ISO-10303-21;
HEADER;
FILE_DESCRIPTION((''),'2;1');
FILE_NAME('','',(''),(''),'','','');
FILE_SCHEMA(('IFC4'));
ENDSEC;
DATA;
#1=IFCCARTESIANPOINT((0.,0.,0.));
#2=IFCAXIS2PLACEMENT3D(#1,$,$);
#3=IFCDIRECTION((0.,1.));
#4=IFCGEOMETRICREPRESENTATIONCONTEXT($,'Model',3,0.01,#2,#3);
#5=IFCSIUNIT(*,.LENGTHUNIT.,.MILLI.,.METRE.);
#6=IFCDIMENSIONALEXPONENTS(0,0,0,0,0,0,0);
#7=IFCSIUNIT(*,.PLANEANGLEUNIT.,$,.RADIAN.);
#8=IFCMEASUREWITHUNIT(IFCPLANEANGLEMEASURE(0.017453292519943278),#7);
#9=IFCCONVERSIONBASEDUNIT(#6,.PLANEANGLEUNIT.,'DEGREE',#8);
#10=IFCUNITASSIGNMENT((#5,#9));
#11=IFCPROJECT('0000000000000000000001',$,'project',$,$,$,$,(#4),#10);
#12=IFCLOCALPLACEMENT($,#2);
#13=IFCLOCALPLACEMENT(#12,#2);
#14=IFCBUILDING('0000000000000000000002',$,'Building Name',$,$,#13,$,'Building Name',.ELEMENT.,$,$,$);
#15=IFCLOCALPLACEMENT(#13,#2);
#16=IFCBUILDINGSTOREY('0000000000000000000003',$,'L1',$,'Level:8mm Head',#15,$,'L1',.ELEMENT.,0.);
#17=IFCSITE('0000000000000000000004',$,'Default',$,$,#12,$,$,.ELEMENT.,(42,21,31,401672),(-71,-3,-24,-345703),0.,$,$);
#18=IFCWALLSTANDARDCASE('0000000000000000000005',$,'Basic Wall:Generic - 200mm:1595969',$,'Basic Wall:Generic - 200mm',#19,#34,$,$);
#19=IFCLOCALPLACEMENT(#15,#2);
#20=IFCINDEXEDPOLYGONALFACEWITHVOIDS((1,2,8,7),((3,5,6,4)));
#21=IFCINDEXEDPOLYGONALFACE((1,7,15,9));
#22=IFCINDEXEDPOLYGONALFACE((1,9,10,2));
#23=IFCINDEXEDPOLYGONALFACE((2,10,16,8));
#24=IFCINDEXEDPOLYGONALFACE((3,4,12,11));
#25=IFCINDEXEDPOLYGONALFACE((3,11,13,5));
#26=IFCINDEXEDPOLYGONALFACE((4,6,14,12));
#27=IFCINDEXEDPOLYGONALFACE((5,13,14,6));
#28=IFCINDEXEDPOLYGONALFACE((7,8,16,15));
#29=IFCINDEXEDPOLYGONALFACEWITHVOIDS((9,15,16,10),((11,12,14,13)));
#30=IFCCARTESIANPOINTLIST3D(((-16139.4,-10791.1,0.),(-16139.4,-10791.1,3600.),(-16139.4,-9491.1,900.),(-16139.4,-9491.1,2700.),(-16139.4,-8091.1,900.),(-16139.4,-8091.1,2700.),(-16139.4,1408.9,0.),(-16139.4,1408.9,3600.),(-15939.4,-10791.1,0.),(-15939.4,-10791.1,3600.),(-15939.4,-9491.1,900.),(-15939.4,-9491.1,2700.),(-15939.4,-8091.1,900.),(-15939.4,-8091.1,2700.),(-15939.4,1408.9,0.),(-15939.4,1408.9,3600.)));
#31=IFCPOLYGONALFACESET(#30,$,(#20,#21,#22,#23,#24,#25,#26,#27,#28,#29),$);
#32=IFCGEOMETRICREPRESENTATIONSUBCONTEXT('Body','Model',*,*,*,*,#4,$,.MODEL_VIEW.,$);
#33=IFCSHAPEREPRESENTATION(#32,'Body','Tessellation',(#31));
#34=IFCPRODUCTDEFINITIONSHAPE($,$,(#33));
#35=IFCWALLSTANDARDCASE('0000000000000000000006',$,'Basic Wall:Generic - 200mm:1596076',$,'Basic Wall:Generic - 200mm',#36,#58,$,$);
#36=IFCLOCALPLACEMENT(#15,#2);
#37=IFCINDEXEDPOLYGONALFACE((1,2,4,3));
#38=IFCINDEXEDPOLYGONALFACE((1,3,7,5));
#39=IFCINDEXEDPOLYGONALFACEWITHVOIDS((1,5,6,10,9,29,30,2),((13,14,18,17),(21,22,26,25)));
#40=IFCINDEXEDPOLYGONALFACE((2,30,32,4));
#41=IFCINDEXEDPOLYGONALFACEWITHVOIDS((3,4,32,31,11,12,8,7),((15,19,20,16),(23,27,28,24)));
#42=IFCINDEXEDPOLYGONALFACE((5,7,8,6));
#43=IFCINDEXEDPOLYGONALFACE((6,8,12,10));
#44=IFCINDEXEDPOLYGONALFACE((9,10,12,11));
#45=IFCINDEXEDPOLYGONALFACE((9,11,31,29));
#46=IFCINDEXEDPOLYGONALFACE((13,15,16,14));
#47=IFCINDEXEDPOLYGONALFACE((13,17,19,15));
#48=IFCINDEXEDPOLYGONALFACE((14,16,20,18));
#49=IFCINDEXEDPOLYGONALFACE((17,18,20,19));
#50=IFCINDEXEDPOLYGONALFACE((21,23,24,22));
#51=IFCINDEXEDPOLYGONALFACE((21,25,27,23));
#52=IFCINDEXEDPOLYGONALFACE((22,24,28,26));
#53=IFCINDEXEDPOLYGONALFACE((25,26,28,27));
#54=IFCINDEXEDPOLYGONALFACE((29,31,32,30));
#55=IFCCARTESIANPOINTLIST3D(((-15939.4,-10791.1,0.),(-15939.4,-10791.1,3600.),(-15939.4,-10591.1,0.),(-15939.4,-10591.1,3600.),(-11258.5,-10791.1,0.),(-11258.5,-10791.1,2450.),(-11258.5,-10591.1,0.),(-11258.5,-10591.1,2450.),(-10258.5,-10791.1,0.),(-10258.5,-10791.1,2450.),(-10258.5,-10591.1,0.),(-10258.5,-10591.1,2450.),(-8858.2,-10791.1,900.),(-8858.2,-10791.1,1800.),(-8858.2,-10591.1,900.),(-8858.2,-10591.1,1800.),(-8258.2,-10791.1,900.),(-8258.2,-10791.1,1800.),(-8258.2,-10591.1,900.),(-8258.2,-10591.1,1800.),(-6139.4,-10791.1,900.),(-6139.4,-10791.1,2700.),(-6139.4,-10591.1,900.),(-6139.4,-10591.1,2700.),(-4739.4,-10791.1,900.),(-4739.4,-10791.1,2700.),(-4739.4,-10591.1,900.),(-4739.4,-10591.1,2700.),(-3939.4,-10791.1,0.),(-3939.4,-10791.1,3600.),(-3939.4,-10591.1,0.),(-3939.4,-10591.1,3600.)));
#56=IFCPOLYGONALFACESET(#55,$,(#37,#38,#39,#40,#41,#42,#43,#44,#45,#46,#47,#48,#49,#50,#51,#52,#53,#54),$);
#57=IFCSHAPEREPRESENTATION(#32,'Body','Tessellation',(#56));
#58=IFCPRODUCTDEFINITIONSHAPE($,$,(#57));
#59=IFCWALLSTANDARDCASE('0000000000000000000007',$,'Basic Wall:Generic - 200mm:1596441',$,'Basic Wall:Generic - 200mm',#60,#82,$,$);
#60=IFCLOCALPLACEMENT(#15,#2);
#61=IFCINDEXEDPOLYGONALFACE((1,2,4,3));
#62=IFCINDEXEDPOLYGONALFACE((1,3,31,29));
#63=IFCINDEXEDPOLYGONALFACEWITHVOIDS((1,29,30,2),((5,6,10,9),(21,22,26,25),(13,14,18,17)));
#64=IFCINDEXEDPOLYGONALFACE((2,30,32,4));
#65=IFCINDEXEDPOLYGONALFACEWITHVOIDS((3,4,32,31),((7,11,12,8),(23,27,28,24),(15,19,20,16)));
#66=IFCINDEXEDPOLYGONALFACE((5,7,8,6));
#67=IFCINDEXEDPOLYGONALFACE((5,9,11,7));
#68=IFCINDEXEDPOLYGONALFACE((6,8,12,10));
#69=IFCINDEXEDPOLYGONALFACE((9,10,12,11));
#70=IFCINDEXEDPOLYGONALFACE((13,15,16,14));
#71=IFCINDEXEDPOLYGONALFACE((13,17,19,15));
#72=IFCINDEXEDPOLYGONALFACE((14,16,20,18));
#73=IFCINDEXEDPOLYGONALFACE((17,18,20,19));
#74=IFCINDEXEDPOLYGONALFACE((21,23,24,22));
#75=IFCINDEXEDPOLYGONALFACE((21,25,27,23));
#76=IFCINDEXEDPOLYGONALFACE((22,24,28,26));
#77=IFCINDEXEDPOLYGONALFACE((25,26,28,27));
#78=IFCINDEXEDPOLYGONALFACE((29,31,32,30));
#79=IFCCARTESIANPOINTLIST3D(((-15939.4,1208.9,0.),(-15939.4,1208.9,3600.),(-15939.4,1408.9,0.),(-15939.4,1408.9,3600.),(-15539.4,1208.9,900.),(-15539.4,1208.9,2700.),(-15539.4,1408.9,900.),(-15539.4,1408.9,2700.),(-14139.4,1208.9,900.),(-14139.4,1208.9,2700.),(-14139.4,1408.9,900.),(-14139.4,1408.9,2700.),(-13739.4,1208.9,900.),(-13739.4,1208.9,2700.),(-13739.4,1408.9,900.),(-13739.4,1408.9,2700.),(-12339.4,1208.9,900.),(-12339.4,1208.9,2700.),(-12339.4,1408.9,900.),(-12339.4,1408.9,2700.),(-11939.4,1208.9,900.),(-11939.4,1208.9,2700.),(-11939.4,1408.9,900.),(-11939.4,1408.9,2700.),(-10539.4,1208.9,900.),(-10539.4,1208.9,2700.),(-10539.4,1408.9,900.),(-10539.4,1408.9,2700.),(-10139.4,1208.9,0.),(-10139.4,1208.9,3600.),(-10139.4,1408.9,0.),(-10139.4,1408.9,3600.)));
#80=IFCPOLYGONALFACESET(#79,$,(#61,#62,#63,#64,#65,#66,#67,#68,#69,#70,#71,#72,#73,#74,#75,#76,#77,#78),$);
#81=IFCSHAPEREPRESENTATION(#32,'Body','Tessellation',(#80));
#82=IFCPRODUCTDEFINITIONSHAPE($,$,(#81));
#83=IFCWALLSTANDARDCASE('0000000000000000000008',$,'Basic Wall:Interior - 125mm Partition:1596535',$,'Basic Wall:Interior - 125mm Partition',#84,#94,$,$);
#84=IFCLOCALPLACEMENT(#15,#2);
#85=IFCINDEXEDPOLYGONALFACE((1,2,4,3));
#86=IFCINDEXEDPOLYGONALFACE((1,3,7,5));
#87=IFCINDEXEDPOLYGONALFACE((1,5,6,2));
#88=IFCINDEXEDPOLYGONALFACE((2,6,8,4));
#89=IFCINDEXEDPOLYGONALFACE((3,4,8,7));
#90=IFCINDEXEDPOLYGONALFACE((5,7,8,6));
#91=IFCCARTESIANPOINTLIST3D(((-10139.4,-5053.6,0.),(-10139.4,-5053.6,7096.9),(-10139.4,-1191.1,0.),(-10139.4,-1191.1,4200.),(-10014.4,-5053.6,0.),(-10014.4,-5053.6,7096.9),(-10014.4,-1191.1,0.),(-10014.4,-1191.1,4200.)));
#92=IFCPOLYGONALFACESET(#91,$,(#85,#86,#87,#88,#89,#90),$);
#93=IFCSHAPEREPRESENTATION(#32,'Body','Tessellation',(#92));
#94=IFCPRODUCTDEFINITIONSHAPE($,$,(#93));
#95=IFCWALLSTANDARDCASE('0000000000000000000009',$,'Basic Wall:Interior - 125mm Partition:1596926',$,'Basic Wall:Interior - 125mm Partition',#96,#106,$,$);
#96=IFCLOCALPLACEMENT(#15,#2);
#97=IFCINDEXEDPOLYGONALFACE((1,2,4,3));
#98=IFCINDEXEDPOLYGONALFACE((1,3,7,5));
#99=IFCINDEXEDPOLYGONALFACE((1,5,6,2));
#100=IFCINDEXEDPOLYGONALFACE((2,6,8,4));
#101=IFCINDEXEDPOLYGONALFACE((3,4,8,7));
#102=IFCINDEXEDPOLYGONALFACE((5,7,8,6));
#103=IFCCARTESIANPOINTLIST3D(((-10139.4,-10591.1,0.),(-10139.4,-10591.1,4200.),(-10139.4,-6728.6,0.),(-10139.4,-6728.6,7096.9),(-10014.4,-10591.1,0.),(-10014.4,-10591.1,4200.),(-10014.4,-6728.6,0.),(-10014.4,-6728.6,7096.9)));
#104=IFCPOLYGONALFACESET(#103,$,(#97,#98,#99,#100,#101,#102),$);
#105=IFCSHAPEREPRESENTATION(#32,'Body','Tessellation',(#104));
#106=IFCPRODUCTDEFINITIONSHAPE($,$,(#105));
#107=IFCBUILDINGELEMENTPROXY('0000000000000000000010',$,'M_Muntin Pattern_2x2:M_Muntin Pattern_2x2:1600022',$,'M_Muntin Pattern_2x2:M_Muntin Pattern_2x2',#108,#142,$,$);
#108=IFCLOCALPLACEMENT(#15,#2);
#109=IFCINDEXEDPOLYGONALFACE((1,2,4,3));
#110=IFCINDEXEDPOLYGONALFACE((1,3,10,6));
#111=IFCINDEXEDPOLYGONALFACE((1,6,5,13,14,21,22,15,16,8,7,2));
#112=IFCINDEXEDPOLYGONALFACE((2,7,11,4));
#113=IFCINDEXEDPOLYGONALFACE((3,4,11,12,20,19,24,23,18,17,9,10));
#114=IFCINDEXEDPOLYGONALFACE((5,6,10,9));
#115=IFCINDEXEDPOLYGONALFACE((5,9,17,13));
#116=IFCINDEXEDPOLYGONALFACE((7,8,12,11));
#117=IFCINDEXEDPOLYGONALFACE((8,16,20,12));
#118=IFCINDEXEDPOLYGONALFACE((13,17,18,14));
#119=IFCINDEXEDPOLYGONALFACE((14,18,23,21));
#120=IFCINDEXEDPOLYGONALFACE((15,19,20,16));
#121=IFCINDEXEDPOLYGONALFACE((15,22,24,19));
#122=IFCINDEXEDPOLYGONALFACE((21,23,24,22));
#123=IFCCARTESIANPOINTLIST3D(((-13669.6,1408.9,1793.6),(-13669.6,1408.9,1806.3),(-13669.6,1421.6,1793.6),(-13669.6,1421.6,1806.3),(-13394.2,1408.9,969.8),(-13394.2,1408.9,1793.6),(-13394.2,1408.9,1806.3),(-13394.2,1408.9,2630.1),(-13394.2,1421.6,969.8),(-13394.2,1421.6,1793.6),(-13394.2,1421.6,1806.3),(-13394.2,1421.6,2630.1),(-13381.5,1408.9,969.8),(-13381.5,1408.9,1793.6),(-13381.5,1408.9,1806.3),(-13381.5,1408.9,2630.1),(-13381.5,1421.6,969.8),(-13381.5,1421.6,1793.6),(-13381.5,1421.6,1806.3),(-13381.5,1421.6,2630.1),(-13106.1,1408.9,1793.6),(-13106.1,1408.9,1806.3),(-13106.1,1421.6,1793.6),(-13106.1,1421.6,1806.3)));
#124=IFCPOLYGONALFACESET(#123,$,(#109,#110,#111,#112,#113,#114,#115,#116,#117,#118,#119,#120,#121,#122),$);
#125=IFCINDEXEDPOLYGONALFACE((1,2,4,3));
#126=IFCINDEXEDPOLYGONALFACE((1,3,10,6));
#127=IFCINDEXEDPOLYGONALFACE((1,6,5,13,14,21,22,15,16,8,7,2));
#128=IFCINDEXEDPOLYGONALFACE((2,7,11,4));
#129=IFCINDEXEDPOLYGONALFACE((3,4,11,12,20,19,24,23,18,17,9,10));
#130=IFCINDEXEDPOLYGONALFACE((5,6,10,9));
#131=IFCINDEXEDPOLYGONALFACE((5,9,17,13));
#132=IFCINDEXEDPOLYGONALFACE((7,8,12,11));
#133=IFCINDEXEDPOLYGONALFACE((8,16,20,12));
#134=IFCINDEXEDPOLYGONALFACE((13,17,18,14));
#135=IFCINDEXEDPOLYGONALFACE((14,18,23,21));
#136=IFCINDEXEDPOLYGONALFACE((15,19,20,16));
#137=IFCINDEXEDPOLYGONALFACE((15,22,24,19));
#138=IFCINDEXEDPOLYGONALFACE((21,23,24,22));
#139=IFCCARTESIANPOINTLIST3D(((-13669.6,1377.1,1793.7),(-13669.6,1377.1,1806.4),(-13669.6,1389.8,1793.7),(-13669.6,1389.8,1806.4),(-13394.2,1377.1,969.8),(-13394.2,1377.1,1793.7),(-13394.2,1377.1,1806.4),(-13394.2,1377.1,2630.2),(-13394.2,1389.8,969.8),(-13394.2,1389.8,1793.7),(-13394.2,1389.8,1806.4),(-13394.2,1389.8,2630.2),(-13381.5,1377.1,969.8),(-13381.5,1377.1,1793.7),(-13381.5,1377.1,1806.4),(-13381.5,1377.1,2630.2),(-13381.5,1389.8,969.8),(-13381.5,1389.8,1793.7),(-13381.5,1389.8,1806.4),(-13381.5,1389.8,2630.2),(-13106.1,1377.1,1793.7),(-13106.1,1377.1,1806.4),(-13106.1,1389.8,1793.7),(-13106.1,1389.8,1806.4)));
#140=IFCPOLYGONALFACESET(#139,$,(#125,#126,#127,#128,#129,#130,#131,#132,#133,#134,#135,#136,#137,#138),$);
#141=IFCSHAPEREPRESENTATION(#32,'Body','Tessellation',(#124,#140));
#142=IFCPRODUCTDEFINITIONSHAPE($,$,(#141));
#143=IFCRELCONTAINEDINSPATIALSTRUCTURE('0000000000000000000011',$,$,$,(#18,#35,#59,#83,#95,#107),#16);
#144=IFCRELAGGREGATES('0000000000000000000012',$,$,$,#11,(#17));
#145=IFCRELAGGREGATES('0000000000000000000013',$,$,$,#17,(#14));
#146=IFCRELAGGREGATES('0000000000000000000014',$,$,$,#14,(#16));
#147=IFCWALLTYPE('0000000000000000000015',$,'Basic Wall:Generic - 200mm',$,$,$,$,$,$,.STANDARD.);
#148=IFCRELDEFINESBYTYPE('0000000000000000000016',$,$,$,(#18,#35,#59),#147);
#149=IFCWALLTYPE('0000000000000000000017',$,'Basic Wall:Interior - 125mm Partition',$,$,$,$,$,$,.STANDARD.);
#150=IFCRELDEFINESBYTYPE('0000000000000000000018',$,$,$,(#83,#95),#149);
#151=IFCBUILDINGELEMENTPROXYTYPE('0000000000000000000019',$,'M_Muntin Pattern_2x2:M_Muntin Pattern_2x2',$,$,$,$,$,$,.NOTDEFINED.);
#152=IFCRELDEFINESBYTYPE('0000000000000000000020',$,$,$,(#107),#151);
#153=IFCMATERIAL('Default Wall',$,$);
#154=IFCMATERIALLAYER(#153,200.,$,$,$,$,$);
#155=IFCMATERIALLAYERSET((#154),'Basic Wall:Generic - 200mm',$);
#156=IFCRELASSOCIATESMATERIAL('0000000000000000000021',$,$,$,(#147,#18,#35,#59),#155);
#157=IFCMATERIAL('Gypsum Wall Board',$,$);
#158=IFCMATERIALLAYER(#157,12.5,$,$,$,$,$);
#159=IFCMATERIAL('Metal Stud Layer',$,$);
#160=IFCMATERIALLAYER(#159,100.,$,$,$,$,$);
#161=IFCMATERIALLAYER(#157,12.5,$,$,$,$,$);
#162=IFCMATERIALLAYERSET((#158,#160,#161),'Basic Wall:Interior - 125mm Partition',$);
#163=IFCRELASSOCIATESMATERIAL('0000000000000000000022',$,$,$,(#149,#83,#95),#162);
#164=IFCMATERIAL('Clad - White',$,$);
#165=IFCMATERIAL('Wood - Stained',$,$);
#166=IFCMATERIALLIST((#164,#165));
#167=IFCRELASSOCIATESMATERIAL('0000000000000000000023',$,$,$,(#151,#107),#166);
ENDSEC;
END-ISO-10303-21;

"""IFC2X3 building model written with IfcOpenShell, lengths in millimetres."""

from ifc_helpers import new_model, entity, si_unit, converted_unit, direction, frame, frame_2d, origin, place, context, subcontext, project, spatial, polyline, rectangle, outline, extrude, clip, bounded_halfspace, source, transform, mapped, material, material_list, layer, layer_set, layer_usage, type_object, type_shapes, element, save


model = new_model("IFC2X3")

# Units and contexts
model_context = context("Model", 3, precision=0.01, world=origin(), true_north=direction((0.0, 1.0)))
body_context = subcontext(model_context, "Body", "Model", "MODEL_VIEW")
ifc_project = project(units=[si_unit("LENGTHUNIT", "METRE", prefix="MILLI"), converted_unit("PLANEANGLEUNIT", "DEGREE", entity("IfcPlaneAngleMeasure", 0.017453292519943278), si_unit("PLANEANGLEUNIT", "RADIAN"), dimensions=[0, 0, 0, 0, 0, 0, 0])], contexts=[model_context])

# Site, building, storey
site_placement = place(None, origin())
site = spatial("IfcSite", under=ifc_project, at=site_placement, Name="Default", CompositionType="ELEMENT", RefLatitude=(42, 21, 31, 401672), RefLongitude=(-71, -3, -24, -345703), RefElevation=0.0)
building_placement = place(site_placement, origin())
building = spatial("IfcBuilding", under=site, at=building_placement, Name="Building Name", LongName="Building Name", CompositionType="ELEMENT")
storey_placement = place(building_placement, origin())
storey = spatial("IfcBuildingStorey", under=building, at=storey_placement, Name="L1", ObjectType="Level:8mm Head", LongName="L1", CompositionType="ELEMENT", Elevation=0.0)

# Wall, opening
ifc_material_1 = material(Name="Default Wall")
ifc_layer_1 = layer(ifc_material_1, 200.0)
ifc_layer_set_1 = layer_set([ifc_layer_1], Name="Basic Wall:Generic - 200mm")
ifc_layer_usage_1 = layer_usage(ifc_layer_set_1, "AXIS2", "NEGATIVE", 100.0)
wall_type_1 = type_object("IfcWallType", Name="Basic Wall:Generic - 200mm", PredefinedType="STANDARD", material=ifc_layer_set_1)
wall_1_placement = place(storey_placement, frame((-16039.4, 1408.9, 0.0), z_axis=(0.0, 0.0, 1.0), x_axis=(0.0, -1.0, 0.0)))
wall_1 = element("IfcWallStandardCase", 1, at=wall_1_placement, inside=storey, type_object=wall_type_1, material=ifc_layer_usage_1, Name="Basic Wall:Generic - 200mm:1595969", ObjectType="Basic Wall:Generic - 200mm", context=body_context, shape_type="SweptSolid", body=[
    extrude(rectangle(XDim=12200.0, YDim=200.0, at=frame_2d((6100.0, 0.0), x_axis=(-1.0, 0.0))), origin(), (0.0, 0.0, 1.0), 3600.0),
])
opening_1_placement = place(wall_1_placement, frame((10900.0, 100.0, 900.0)))
element("IfcOpeningElement", 2, at=opening_1_placement, cuts=wall_1, ObjectType="Opening", context=body_context, shape_type="SweptSolid", body=[
    extrude(rectangle(XDim=1800.0, YDim=1400.0, at=frame_2d((900.0, 700.0), x_axis=(-1.0, 0.0))), frame((0.0, 0.0, 0.0), z_axis=(0.0, -1.0, 0.0), x_axis=(0.0, 0.0, 1.0)), (0.0, 0.0, 1.0), 200.0),
])

# Walls, openings
wall_2_placement = place(storey_placement, frame((-15939.4, -10691.1, 0.0)))
wall_2 = element("IfcWallStandardCase", 3, at=wall_2_placement, inside=storey, type_object=wall_type_1, material=ifc_layer_usage_1, Name="Basic Wall:Generic - 200mm:1596076", ObjectType="Basic Wall:Generic - 200mm", context=body_context, shape_type="SweptSolid", body=[
    extrude(rectangle(XDim=12000.0, YDim=200.0, at=frame_2d((6000.0, 0.0), x_axis=(1.0, 0.0))), origin(), (0.0, 0.0, 1.0), 3600.0),
])
opening_2_placement = place(wall_2_placement, frame((4680.9, -100.0, 0.0)))
element("IfcOpeningElement", 4, at=opening_2_placement, cuts=wall_2, ObjectType="Opening", context=body_context, shape_type="SweptSolid", body=[
    extrude(rectangle(XDim=2450.0, YDim=1000.0, at=frame_2d((1225.0, 500.0), x_axis=(1.0, 0.0))), frame((0.0, 0.0, 0.0), z_axis=(0.0, 1.0, 0.0), x_axis=(0.0, 0.0, 1.0)), (0.0, 0.0, 1.0), 200.0),
])
opening_3_placement = place(wall_2_placement, frame((11200.0, 100.0, 900.0)))
element("IfcOpeningElement", 5, at=opening_3_placement, cuts=wall_2, ObjectType="Opening", context=body_context, shape_type="SweptSolid", body=[
    extrude(rectangle(XDim=1800.0, YDim=1400.0, at=frame_2d((900.0, 700.0), x_axis=(-1.0, 0.0))), frame((0.0, 0.0, 0.0), z_axis=(0.0, -1.0, 0.0), x_axis=(0.0, 0.0, 1.0)), (0.0, 0.0, 1.0), 200.0),
])
opening_4_placement = place(wall_2_placement, frame((7081.2, -100.0, 900.0)))
element("IfcOpeningElement", 6, at=opening_4_placement, cuts=wall_2, ObjectType="Opening", context=body_context, shape_type="SweptSolid", body=[
    extrude(rectangle(XDim=900.0, YDim=600.0, at=frame_2d((450.0, 300.0), x_axis=(-1.0, 0.0))), frame((0.0, 0.0, 0.0), z_axis=(0.0, 1.0, 0.0), x_axis=(0.0, 0.0, 1.0)), (0.0, 0.0, 1.0), 200.0),
])
wall_3_placement = place(storey_placement, frame((-10139.4, 1308.9, 0.0), z_axis=(0.0, 0.0, 1.0), x_axis=(-1.0, 0.0, 0.0)))
wall_3 = element("IfcWallStandardCase", 7, at=wall_3_placement, inside=storey, type_object=wall_type_1, material=ifc_layer_usage_1, Name="Basic Wall:Generic - 200mm:1596441", ObjectType="Basic Wall:Generic - 200mm", context=body_context, shape_type="SweptSolid", body=[
    extrude(rectangle(XDim=5800.0, YDim=200.0, at=frame_2d((2900.0, 0.0), x_axis=(-1.0, 0.0))), origin(), (0.0, 0.0, 1.0), 3600.0),
])
opening_5_placement = place(wall_3_placement, frame((3600.0, 100.0, 900.0)))
element("IfcOpeningElement", 8, at=opening_5_placement, cuts=wall_3, ObjectType="Opening", context=body_context, shape_type="SweptSolid", body=[
    extrude(rectangle(XDim=1800.0, YDim=1400.0, at=frame_2d((900.0, 700.0), x_axis=(-1.0, 0.0))), frame((0.0, 0.0, 0.0), z_axis=(0.0, -1.0, 0.0), x_axis=(0.0, 0.0, 1.0)), (0.0, 0.0, 1.0), 200.0),
])
opening_6_placement = place(wall_3_placement, frame((1800.0, 100.0, 900.0)))
element("IfcOpeningElement", 9, at=opening_6_placement, cuts=wall_3, ObjectType="Opening", context=body_context, shape_type="SweptSolid", body=[
    extrude(rectangle(XDim=1800.0, YDim=1400.0, at=frame_2d((900.0, 700.0), x_axis=(-1.0, 0.0))), frame((0.0, 0.0, 0.0), z_axis=(0.0, -1.0, 0.0), x_axis=(0.0, 0.0, 1.0)), (0.0, 0.0, 1.0), 200.0),
])
opening_7_placement = place(wall_3_placement, frame((5400.0, 100.0, 900.0)))
element("IfcOpeningElement", 10, at=opening_7_placement, cuts=wall_3, ObjectType="Opening", context=body_context, shape_type="SweptSolid", body=[
    extrude(rectangle(XDim=1800.0, YDim=1400.0, at=frame_2d((900.0, 700.0), x_axis=(-1.0, 0.0))), frame((0.0, 0.0, 0.0), z_axis=(0.0, -1.0, 0.0), x_axis=(0.0, 0.0, 1.0)), (0.0, 0.0, 1.0), 200.0),
])

# Walls
ifc_material_2 = material(Name="Gypsum Wall Board")
ifc_layer_2 = layer(ifc_material_2, 12.5)
ifc_material_3 = material(Name="Metal Stud Layer")
ifc_layer_3 = layer(ifc_material_3, 100.0)
ifc_layer_4 = layer(ifc_material_2, 12.5)
ifc_layer_set_2 = layer_set([ifc_layer_2, ifc_layer_3, ifc_layer_4], Name="Basic Wall:Interior - 125mm Partition")
ifc_layer_usage_2 = layer_usage(ifc_layer_set_2, "AXIS2", "NEGATIVE", 62.5)
wall_type_2 = type_object("IfcWallType", Name="Basic Wall:Interior - 125mm Partition", PredefinedType="STANDARD", material=ifc_layer_set_2)
wall_4_placement = place(storey_placement, frame((-10076.9, -1191.1, 0.0), z_axis=(0.0, 0.0, 1.0), x_axis=(0.0, -1.0, 0.0)))
element("IfcWallStandardCase", 11, at=wall_4_placement, inside=storey, type_object=wall_type_2, material=ifc_layer_usage_2, Name="Basic Wall:Interior - 125mm Partition:1596535", ObjectType="Basic Wall:Interior - 125mm Partition", context=body_context, shape_type="Clipping", body=[
    clip(extrude(rectangle(XDim=3862.5, YDim=125.0, at=frame_2d((1931.3, 0.0), x_axis=(-1.0, 0.0))), origin(), (0.0, 0.0, 1.0), 7096.9), bounded_halfspace(frame((0.0, -62.5, 4200.0), z_axis=(-0.6, 0.0, 0.8), x_axis=(0.0, -1.0, 0.0)), False, frame((0.0, -62.5, 4200.0)), polyline([(0.0, 0.0), (3862.5, 0.0), (3862.5, 125.0), (3737.5, 125.0), (0.0, 125.0), (0.0, 0.0)]))),
])
wall_5_placement = place(storey_placement, frame((-10076.9, -10591.1, 0.0), z_axis=(0.0, 0.0, 1.0), x_axis=(0.0, 1.0, 0.0)))
element("IfcWallStandardCase", 12, at=wall_5_placement, inside=storey, type_object=wall_type_2, material=ifc_layer_usage_2, Name="Basic Wall:Interior - 125mm Partition:1596926", ObjectType="Basic Wall:Interior - 125mm Partition", context=body_context, shape_type="Clipping", body=[
    clip(extrude(rectangle(XDim=3862.5, YDim=125.0, at=frame_2d((1931.3, 0.0), x_axis=(-1.0, 0.0))), origin(), (0.0, 0.0, 1.0), 7096.9), bounded_halfspace(frame((0.0, -62.5, 4200.0), z_axis=(-0.6, 0.0, 0.8), x_axis=(0.0, -1.0, 0.0)), False, frame((0.0, -62.5, 4200.0)), polyline([(0.0, 0.0), (3737.5, 0.0), (3862.5, 0.0), (3862.5, 125.0), (0.0, 125.0), (0.0, 0.0)]))),
])

# Building element proxy
ifc_material_4 = material(Name="Clad - White")
ifc_material_5 = material(Name="Wood - Stained")
ifc_material_list = material_list([ifc_material_4, ifc_material_5])
building_element_proxy_type_1 = type_object("IfcBuildingElementProxyType", Name="M_Muntin Pattern_2x2:M_Muntin Pattern_2x2", PredefinedType="NOTDEFINED", material=ifc_material_list)
shared_shape_1 = source(origin(), body_context, "Body", "SweptSolid", [
    extrude(outline(polyline([(6.4, -6.4), (830.1, -6.4), (830.1, 6.3), (6.4, 6.3), (6.4, 281.7), (-6.3, 281.7), (-6.3, 6.3), (-830.2, 6.3), (-830.2, -6.4), (-6.3, -6.4), (-6.3, -281.7), (6.4, -281.7), (6.4, -6.4)])), frame((0.0, 9.5, 830.1), z_axis=(0.0, 1.0, 0.0), x_axis=(0.0, 0.0, 1.0)), (0.0, 0.0, 1.0), 12.7),
    extrude(outline(polyline([(6.4, -6.4), (830.2, -6.4), (830.2, 6.3), (6.4, 6.3), (6.4, 281.7), (-6.3, 281.7), (-6.3, 6.3), (-830.2, 6.3), (-830.2, -6.4), (-6.3, -6.4), (-6.3, -281.7), (6.4, -281.7), (6.4, -6.4)])), frame((0.0, -22.2, 830.2), z_axis=(0.0, 1.0, 0.0), x_axis=(0.0, 0.0, 1.0)), (0.0, 0.0, 1.0), 12.7),
])
type_shapes(building_element_proxy_type_1, [shared_shape_1])
for number, where, name in (
    (13, (-13387.9, 1399.4, 969.8), "M_Muntin Pattern_2x2:M_Muntin Pattern_2x2:1600022"),
):
    element("IfcBuildingElementProxy", number, at=place(storey_placement, frame(where)), inside=storey, type_object=building_element_proxy_type_1, material=ifc_material_list, Name=name, ObjectType="M_Muntin Pattern_2x2:M_Muntin Pattern_2x2", context=body_context, shape_type="MappedRepresentation", body=[
        mapped(shared_shape_1, transform((0.0, 0.0, 0.0), scale=1.0)),
    ])

save(model, "model.ifc")
